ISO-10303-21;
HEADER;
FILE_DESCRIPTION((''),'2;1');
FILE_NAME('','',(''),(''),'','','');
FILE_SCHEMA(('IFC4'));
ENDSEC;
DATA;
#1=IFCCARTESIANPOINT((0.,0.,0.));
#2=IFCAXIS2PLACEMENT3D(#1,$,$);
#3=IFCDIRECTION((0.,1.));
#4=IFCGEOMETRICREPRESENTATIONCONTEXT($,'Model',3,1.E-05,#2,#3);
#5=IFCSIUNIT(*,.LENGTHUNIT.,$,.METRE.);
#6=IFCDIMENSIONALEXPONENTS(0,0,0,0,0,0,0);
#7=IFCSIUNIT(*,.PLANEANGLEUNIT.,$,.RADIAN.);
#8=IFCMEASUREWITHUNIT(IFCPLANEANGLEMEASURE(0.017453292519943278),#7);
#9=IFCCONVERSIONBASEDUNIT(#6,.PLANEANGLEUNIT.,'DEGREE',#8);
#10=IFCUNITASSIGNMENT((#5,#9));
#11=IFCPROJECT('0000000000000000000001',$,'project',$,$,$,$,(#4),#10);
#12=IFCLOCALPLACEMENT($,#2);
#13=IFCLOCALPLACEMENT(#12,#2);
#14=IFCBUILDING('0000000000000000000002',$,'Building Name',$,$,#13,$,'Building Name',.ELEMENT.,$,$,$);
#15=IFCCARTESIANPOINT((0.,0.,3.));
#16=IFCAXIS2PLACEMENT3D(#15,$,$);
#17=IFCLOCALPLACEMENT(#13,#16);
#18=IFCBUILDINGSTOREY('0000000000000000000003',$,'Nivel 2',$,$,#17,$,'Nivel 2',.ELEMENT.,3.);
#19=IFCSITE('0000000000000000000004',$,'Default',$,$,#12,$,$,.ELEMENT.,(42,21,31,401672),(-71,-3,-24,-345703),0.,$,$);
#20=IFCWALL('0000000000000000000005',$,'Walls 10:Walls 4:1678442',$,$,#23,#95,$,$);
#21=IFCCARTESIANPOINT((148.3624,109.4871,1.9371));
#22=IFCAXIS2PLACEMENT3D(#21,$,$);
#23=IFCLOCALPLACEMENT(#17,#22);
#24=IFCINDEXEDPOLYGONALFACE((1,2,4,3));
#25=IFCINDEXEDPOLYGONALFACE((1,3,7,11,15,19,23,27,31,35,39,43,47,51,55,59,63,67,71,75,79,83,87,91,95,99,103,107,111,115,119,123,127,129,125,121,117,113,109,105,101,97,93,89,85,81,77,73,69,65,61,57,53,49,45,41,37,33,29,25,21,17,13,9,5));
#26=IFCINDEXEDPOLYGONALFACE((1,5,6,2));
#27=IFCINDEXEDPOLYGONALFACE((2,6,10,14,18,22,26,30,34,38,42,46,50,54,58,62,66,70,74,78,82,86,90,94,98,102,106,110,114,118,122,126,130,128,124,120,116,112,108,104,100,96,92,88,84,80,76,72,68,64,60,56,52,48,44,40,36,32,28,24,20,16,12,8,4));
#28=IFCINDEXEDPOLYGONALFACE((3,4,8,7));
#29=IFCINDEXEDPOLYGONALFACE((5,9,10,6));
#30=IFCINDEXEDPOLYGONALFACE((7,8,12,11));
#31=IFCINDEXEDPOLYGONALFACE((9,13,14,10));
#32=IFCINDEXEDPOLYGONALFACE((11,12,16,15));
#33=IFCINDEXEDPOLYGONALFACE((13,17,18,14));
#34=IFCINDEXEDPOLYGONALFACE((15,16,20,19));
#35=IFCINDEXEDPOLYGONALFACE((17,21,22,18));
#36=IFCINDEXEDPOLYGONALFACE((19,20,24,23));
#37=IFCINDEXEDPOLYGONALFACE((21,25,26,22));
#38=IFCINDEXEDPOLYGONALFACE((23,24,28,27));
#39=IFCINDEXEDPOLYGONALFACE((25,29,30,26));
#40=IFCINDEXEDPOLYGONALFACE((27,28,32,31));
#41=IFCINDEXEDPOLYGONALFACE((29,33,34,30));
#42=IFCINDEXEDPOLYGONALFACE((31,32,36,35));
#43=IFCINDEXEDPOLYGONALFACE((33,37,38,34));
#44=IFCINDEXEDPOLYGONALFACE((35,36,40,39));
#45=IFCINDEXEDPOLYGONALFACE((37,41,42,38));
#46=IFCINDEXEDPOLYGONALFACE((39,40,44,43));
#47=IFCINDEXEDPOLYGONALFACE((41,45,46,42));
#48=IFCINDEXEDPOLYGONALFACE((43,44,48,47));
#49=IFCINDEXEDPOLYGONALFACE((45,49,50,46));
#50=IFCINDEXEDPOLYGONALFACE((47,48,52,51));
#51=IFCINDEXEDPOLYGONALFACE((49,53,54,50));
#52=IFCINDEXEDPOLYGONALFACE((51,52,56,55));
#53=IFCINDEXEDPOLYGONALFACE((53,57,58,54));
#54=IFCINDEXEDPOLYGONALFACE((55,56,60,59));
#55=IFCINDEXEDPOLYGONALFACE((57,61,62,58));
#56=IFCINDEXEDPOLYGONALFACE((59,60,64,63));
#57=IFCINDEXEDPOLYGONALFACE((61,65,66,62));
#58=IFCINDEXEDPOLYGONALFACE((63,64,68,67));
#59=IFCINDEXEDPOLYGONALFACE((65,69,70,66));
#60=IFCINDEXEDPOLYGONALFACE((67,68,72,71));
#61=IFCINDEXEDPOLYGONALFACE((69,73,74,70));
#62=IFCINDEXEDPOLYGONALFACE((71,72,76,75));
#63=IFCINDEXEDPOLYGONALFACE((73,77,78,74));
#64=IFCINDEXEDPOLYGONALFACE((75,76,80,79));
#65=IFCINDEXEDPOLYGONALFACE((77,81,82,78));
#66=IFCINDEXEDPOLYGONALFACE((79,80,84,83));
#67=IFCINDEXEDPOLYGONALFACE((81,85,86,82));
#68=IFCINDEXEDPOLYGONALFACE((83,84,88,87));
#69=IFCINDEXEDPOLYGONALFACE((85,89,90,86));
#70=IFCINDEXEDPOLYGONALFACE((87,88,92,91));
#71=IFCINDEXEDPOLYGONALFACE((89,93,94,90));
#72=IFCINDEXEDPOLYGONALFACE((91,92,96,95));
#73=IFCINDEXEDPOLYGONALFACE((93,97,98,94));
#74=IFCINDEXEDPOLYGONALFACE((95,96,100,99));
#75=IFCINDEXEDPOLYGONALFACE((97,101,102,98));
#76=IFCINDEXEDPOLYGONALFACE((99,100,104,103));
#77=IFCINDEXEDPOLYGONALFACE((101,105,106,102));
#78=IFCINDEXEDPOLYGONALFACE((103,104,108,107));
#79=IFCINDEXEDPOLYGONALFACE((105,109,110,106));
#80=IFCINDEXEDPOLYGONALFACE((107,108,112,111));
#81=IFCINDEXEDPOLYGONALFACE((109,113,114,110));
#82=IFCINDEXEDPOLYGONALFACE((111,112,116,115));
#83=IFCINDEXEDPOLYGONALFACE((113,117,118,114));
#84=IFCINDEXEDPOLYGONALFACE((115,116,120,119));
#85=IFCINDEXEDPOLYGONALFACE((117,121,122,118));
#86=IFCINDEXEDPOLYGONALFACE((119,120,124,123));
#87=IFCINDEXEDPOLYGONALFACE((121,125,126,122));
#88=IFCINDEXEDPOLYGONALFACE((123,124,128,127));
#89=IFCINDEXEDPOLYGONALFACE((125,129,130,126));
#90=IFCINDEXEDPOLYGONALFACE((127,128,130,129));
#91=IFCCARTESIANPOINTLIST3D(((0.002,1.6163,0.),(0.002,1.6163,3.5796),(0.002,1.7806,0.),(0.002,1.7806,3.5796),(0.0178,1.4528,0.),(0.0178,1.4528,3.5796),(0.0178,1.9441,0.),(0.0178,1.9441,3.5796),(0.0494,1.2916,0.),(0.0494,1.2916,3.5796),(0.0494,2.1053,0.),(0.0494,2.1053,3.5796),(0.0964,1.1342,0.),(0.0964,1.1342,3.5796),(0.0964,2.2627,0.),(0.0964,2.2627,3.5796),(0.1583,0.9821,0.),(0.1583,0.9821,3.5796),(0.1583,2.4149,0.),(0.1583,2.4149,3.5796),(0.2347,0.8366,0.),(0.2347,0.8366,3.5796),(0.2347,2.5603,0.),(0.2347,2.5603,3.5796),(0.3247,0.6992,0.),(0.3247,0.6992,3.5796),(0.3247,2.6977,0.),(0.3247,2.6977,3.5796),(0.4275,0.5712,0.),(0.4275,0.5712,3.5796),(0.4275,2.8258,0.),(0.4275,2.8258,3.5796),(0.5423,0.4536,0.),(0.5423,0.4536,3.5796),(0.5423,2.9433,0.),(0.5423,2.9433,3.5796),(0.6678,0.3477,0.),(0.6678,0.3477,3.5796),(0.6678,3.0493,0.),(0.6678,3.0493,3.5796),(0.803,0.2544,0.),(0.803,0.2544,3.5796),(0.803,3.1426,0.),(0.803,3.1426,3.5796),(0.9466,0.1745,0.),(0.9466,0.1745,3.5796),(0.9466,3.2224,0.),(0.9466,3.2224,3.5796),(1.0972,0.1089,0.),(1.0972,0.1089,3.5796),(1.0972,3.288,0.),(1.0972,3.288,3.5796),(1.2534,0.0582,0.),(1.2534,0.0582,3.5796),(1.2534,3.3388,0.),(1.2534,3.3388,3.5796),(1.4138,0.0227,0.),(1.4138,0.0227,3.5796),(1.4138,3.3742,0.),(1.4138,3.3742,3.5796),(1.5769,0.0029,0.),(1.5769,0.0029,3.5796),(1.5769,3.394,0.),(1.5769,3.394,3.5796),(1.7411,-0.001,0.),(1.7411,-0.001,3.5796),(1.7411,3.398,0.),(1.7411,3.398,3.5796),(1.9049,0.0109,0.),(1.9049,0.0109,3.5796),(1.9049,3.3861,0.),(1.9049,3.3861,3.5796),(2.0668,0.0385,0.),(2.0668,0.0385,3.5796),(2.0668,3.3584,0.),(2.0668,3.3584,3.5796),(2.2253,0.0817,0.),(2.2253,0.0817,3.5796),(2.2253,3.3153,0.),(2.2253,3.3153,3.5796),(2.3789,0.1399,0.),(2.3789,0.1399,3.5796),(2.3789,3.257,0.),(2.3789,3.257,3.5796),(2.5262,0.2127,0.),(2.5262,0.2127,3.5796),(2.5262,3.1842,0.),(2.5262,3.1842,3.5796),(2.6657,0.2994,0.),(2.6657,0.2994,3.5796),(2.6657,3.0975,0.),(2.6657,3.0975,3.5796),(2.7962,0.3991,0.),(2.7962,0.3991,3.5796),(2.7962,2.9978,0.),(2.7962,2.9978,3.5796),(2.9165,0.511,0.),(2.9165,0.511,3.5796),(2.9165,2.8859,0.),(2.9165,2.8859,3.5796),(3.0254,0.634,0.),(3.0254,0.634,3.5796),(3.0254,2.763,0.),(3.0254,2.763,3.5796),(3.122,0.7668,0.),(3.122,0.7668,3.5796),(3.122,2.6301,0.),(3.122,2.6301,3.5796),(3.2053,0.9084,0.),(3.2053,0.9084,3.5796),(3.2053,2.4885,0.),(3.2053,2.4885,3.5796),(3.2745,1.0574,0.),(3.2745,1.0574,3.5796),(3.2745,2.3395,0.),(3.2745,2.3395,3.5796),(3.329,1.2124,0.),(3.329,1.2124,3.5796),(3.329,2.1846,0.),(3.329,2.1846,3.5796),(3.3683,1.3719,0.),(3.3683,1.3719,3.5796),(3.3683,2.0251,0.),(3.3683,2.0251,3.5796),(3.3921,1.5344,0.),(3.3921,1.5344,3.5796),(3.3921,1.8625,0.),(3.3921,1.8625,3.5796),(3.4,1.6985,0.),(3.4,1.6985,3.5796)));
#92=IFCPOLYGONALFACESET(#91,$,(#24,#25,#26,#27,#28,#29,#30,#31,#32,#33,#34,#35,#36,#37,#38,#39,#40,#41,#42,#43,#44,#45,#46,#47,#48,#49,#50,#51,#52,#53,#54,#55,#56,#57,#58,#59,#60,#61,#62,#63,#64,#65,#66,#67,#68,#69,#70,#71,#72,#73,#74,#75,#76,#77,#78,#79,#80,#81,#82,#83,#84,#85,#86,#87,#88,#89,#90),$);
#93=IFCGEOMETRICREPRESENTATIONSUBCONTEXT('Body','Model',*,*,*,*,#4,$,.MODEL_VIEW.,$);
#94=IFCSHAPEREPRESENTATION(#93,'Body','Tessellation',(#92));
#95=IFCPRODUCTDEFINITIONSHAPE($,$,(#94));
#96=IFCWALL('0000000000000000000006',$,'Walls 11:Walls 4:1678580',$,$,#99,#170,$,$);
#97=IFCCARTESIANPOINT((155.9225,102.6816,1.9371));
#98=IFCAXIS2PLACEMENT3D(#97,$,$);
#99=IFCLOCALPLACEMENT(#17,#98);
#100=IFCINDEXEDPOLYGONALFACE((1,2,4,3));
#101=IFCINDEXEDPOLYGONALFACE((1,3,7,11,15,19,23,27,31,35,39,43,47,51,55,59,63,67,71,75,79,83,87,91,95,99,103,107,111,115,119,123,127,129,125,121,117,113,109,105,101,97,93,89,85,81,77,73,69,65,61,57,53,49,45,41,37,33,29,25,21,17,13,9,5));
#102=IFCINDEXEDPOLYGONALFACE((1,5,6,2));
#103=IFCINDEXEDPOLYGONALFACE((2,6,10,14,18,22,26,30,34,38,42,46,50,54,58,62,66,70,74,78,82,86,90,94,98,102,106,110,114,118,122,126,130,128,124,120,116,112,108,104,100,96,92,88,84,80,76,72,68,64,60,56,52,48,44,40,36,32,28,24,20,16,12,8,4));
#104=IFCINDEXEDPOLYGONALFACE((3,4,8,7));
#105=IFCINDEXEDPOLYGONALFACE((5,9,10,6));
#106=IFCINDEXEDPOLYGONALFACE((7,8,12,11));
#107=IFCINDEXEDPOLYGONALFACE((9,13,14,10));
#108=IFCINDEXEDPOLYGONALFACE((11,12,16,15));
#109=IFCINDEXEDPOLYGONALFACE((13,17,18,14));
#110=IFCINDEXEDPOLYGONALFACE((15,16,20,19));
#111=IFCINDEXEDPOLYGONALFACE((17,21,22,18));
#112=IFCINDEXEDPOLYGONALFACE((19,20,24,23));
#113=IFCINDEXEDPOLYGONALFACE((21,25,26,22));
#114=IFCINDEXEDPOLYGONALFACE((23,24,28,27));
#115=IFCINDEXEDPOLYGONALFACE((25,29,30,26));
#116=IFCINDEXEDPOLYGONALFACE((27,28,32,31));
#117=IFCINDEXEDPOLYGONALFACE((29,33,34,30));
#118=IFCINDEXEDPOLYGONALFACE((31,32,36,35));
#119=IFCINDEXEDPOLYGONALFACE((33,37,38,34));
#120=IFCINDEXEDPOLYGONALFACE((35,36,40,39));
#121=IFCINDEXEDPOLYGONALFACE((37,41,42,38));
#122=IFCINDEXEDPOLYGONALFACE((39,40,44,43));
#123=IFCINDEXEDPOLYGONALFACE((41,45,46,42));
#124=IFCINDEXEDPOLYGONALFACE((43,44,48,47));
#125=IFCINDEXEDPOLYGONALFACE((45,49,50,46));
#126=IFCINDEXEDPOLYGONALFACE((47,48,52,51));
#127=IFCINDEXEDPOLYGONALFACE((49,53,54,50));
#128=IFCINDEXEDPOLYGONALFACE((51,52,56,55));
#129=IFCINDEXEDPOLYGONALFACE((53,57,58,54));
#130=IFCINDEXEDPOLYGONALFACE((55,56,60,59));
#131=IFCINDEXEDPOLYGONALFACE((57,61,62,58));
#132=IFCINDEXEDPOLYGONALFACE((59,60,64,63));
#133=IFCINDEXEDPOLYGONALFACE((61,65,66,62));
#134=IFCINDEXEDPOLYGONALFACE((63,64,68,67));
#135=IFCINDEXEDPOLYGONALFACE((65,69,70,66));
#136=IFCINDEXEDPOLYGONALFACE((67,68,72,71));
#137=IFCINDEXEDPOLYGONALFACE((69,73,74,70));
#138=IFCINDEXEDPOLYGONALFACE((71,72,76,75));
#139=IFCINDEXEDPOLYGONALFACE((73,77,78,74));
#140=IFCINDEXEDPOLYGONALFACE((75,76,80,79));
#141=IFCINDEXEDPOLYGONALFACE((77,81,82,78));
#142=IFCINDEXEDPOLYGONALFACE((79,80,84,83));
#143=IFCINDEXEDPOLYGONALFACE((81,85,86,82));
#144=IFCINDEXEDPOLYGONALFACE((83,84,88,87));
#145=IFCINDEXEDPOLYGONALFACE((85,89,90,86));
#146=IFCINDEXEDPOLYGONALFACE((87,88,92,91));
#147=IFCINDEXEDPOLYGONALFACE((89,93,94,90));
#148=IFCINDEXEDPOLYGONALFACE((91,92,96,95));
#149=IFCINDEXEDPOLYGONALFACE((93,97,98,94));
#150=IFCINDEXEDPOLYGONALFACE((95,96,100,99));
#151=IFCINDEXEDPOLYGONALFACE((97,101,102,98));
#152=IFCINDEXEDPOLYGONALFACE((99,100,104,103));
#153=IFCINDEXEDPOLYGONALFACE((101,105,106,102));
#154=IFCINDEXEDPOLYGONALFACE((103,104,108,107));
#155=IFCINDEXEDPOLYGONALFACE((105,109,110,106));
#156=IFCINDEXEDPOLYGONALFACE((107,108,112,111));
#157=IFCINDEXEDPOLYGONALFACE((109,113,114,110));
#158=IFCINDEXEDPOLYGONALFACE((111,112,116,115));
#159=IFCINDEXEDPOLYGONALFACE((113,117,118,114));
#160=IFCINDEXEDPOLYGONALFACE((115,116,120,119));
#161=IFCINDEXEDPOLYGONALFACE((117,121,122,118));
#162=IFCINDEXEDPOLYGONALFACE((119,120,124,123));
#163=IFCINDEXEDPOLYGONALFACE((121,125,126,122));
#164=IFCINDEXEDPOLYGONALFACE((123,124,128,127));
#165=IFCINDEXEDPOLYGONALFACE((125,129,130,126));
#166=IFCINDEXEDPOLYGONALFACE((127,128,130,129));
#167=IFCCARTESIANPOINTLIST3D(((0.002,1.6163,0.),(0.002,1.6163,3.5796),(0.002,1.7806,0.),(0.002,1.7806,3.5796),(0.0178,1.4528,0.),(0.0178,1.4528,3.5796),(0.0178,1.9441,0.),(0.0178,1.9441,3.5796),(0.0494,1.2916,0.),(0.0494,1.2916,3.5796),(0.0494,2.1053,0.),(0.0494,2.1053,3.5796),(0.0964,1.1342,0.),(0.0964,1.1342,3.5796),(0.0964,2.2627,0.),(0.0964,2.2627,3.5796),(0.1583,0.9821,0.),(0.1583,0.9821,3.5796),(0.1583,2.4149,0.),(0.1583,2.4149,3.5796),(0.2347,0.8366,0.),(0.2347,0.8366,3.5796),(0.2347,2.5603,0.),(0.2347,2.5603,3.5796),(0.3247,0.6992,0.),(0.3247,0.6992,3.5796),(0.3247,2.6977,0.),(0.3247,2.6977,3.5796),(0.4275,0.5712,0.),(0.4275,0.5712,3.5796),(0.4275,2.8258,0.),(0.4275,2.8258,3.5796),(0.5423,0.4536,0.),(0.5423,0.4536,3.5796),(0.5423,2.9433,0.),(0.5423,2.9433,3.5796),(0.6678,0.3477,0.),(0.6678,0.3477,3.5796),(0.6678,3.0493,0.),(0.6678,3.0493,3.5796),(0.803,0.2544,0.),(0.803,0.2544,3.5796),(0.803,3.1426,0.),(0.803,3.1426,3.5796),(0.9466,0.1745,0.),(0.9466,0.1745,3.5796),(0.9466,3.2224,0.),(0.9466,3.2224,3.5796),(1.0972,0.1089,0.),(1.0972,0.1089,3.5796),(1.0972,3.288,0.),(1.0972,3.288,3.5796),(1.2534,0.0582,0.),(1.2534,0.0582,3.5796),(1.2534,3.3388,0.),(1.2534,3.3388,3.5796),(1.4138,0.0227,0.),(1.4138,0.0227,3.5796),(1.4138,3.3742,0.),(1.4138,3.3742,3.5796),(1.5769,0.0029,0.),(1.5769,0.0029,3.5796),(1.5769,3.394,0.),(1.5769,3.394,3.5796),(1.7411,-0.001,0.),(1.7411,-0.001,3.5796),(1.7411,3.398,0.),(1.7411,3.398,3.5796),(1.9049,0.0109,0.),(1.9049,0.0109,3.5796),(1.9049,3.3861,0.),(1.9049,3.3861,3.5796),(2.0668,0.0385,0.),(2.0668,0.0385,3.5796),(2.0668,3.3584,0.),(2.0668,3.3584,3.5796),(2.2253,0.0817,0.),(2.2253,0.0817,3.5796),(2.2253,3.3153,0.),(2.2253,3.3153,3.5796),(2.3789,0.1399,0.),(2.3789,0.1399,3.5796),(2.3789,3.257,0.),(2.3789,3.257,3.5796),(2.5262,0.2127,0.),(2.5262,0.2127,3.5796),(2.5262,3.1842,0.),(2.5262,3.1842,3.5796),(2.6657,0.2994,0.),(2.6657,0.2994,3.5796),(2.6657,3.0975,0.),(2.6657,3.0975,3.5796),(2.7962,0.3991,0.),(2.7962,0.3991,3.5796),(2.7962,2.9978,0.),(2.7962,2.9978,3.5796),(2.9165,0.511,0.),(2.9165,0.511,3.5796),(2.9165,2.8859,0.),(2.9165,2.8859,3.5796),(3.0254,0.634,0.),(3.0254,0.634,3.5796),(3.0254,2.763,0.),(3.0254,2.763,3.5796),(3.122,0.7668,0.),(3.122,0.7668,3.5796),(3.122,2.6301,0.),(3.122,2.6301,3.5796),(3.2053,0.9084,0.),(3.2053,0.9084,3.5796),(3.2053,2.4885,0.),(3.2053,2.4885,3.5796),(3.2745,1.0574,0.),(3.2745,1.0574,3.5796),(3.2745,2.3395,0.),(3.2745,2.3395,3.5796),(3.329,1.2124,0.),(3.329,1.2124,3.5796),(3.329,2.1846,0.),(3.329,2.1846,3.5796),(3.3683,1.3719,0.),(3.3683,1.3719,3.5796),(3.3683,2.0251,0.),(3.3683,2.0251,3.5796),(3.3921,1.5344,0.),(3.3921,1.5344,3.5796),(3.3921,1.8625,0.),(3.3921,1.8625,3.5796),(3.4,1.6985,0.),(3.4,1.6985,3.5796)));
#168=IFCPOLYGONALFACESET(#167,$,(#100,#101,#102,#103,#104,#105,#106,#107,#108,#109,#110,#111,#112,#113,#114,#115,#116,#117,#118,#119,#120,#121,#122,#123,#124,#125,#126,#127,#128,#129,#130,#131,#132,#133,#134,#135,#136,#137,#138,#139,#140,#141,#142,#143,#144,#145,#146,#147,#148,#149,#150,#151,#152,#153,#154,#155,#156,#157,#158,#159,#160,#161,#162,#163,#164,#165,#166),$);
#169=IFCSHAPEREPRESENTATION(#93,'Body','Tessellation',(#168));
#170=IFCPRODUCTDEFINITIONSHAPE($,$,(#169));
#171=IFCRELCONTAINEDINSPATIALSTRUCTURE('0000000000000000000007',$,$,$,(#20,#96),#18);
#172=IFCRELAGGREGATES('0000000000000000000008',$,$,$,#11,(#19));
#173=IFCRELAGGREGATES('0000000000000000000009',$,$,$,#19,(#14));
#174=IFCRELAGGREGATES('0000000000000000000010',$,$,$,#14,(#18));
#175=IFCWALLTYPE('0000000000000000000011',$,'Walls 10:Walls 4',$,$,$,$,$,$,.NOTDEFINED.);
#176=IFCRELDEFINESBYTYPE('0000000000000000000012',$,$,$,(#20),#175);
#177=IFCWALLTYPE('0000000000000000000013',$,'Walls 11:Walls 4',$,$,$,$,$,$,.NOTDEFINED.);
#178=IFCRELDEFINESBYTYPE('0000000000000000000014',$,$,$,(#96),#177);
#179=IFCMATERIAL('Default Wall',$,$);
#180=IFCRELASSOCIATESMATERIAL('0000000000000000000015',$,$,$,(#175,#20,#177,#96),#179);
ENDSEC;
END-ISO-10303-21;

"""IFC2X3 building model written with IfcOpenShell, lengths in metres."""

from ifc_helpers import new_model, entity, si_unit, converted_unit, direction, frame, origin, origin_2d_with_axis, place, context, subcontext, project, spatial, circle, extrude, material, type_object, element, save


model = new_model("IFC2X3")

# Units and contexts
model_context = context("Model", 3, precision=1e-05, world=origin(), true_north=direction((0.0, 1.0)))
body_context = subcontext(model_context, "Body", "Model", "MODEL_VIEW")
ifc_project = project(units=[si_unit("LENGTHUNIT", "METRE"), converted_unit("PLANEANGLEUNIT", "DEGREE", entity("IfcPlaneAngleMeasure", 0.017453292519943278), si_unit("PLANEANGLEUNIT", "RADIAN"), dimensions=[0, 0, 0, 0, 0, 0, 0])], contexts=[model_context])

# Site, building, storey
site_placement = place(None, origin())
site = spatial("IfcSite", under=ifc_project, at=site_placement, Name="Default", CompositionType="ELEMENT", RefLatitude=(42, 21, 31, 401672), RefLongitude=(-71, -3, -24, -345703), RefElevation=0.0)
building_placement = place(site_placement, origin())
building = spatial("IfcBuilding", under=site, at=building_placement, Name="Building Name", LongName="Building Name", CompositionType="ELEMENT")
storey_placement = place(building_placement, frame((0.0, 0.0, 3.0)))
storey = spatial("IfcBuildingStorey", under=building, at=storey_placement, Name="Nivel 2", LongName="Nivel 2", CompositionType="ELEMENT", Elevation=3.0)

# Walls
ifc_material_1 = material(Name="Default Wall")
wall_type_1 = type_object("IfcWallType", Name="Walls 10:Walls 4", PredefinedType="NOTDEFINED", material=ifc_material_1)
wall_1_placement = place(storey_placement, frame((148.3624, 109.4871, 1.9371)))
element("IfcWall", 1, at=wall_1_placement, inside=storey, type_object=wall_type_1, material=ifc_material_1, Name="Walls 10:Walls 4:1678442", context=body_context, shape_type="SweptSolid", body=[
    extrude(circle(Radius=1.7, at=origin_2d_with_axis()), frame((1.7, 1.6985, 0.0)), (0.0, 0.0, 1.0), 3.5796),
])
wall_type_2 = type_object("IfcWallType", Name="Walls 11:Walls 4", PredefinedType="NOTDEFINED", material=ifc_material_1)
wall_2_placement = place(storey_placement, frame((155.9225, 102.6816, 1.9371)))
element("IfcWall", 2, at=wall_2_placement, inside=storey, type_object=wall_type_2, material=ifc_material_1, Name="Walls 11:Walls 4:1678580", context=body_context, shape_type="SweptSolid", body=[
    extrude(circle(Radius=1.7, at=origin_2d_with_axis()), frame((1.7, 1.6985, 0.0)), (0.0, 0.0, 1.0), 3.5796),
])

save(model, "model.ifc")
